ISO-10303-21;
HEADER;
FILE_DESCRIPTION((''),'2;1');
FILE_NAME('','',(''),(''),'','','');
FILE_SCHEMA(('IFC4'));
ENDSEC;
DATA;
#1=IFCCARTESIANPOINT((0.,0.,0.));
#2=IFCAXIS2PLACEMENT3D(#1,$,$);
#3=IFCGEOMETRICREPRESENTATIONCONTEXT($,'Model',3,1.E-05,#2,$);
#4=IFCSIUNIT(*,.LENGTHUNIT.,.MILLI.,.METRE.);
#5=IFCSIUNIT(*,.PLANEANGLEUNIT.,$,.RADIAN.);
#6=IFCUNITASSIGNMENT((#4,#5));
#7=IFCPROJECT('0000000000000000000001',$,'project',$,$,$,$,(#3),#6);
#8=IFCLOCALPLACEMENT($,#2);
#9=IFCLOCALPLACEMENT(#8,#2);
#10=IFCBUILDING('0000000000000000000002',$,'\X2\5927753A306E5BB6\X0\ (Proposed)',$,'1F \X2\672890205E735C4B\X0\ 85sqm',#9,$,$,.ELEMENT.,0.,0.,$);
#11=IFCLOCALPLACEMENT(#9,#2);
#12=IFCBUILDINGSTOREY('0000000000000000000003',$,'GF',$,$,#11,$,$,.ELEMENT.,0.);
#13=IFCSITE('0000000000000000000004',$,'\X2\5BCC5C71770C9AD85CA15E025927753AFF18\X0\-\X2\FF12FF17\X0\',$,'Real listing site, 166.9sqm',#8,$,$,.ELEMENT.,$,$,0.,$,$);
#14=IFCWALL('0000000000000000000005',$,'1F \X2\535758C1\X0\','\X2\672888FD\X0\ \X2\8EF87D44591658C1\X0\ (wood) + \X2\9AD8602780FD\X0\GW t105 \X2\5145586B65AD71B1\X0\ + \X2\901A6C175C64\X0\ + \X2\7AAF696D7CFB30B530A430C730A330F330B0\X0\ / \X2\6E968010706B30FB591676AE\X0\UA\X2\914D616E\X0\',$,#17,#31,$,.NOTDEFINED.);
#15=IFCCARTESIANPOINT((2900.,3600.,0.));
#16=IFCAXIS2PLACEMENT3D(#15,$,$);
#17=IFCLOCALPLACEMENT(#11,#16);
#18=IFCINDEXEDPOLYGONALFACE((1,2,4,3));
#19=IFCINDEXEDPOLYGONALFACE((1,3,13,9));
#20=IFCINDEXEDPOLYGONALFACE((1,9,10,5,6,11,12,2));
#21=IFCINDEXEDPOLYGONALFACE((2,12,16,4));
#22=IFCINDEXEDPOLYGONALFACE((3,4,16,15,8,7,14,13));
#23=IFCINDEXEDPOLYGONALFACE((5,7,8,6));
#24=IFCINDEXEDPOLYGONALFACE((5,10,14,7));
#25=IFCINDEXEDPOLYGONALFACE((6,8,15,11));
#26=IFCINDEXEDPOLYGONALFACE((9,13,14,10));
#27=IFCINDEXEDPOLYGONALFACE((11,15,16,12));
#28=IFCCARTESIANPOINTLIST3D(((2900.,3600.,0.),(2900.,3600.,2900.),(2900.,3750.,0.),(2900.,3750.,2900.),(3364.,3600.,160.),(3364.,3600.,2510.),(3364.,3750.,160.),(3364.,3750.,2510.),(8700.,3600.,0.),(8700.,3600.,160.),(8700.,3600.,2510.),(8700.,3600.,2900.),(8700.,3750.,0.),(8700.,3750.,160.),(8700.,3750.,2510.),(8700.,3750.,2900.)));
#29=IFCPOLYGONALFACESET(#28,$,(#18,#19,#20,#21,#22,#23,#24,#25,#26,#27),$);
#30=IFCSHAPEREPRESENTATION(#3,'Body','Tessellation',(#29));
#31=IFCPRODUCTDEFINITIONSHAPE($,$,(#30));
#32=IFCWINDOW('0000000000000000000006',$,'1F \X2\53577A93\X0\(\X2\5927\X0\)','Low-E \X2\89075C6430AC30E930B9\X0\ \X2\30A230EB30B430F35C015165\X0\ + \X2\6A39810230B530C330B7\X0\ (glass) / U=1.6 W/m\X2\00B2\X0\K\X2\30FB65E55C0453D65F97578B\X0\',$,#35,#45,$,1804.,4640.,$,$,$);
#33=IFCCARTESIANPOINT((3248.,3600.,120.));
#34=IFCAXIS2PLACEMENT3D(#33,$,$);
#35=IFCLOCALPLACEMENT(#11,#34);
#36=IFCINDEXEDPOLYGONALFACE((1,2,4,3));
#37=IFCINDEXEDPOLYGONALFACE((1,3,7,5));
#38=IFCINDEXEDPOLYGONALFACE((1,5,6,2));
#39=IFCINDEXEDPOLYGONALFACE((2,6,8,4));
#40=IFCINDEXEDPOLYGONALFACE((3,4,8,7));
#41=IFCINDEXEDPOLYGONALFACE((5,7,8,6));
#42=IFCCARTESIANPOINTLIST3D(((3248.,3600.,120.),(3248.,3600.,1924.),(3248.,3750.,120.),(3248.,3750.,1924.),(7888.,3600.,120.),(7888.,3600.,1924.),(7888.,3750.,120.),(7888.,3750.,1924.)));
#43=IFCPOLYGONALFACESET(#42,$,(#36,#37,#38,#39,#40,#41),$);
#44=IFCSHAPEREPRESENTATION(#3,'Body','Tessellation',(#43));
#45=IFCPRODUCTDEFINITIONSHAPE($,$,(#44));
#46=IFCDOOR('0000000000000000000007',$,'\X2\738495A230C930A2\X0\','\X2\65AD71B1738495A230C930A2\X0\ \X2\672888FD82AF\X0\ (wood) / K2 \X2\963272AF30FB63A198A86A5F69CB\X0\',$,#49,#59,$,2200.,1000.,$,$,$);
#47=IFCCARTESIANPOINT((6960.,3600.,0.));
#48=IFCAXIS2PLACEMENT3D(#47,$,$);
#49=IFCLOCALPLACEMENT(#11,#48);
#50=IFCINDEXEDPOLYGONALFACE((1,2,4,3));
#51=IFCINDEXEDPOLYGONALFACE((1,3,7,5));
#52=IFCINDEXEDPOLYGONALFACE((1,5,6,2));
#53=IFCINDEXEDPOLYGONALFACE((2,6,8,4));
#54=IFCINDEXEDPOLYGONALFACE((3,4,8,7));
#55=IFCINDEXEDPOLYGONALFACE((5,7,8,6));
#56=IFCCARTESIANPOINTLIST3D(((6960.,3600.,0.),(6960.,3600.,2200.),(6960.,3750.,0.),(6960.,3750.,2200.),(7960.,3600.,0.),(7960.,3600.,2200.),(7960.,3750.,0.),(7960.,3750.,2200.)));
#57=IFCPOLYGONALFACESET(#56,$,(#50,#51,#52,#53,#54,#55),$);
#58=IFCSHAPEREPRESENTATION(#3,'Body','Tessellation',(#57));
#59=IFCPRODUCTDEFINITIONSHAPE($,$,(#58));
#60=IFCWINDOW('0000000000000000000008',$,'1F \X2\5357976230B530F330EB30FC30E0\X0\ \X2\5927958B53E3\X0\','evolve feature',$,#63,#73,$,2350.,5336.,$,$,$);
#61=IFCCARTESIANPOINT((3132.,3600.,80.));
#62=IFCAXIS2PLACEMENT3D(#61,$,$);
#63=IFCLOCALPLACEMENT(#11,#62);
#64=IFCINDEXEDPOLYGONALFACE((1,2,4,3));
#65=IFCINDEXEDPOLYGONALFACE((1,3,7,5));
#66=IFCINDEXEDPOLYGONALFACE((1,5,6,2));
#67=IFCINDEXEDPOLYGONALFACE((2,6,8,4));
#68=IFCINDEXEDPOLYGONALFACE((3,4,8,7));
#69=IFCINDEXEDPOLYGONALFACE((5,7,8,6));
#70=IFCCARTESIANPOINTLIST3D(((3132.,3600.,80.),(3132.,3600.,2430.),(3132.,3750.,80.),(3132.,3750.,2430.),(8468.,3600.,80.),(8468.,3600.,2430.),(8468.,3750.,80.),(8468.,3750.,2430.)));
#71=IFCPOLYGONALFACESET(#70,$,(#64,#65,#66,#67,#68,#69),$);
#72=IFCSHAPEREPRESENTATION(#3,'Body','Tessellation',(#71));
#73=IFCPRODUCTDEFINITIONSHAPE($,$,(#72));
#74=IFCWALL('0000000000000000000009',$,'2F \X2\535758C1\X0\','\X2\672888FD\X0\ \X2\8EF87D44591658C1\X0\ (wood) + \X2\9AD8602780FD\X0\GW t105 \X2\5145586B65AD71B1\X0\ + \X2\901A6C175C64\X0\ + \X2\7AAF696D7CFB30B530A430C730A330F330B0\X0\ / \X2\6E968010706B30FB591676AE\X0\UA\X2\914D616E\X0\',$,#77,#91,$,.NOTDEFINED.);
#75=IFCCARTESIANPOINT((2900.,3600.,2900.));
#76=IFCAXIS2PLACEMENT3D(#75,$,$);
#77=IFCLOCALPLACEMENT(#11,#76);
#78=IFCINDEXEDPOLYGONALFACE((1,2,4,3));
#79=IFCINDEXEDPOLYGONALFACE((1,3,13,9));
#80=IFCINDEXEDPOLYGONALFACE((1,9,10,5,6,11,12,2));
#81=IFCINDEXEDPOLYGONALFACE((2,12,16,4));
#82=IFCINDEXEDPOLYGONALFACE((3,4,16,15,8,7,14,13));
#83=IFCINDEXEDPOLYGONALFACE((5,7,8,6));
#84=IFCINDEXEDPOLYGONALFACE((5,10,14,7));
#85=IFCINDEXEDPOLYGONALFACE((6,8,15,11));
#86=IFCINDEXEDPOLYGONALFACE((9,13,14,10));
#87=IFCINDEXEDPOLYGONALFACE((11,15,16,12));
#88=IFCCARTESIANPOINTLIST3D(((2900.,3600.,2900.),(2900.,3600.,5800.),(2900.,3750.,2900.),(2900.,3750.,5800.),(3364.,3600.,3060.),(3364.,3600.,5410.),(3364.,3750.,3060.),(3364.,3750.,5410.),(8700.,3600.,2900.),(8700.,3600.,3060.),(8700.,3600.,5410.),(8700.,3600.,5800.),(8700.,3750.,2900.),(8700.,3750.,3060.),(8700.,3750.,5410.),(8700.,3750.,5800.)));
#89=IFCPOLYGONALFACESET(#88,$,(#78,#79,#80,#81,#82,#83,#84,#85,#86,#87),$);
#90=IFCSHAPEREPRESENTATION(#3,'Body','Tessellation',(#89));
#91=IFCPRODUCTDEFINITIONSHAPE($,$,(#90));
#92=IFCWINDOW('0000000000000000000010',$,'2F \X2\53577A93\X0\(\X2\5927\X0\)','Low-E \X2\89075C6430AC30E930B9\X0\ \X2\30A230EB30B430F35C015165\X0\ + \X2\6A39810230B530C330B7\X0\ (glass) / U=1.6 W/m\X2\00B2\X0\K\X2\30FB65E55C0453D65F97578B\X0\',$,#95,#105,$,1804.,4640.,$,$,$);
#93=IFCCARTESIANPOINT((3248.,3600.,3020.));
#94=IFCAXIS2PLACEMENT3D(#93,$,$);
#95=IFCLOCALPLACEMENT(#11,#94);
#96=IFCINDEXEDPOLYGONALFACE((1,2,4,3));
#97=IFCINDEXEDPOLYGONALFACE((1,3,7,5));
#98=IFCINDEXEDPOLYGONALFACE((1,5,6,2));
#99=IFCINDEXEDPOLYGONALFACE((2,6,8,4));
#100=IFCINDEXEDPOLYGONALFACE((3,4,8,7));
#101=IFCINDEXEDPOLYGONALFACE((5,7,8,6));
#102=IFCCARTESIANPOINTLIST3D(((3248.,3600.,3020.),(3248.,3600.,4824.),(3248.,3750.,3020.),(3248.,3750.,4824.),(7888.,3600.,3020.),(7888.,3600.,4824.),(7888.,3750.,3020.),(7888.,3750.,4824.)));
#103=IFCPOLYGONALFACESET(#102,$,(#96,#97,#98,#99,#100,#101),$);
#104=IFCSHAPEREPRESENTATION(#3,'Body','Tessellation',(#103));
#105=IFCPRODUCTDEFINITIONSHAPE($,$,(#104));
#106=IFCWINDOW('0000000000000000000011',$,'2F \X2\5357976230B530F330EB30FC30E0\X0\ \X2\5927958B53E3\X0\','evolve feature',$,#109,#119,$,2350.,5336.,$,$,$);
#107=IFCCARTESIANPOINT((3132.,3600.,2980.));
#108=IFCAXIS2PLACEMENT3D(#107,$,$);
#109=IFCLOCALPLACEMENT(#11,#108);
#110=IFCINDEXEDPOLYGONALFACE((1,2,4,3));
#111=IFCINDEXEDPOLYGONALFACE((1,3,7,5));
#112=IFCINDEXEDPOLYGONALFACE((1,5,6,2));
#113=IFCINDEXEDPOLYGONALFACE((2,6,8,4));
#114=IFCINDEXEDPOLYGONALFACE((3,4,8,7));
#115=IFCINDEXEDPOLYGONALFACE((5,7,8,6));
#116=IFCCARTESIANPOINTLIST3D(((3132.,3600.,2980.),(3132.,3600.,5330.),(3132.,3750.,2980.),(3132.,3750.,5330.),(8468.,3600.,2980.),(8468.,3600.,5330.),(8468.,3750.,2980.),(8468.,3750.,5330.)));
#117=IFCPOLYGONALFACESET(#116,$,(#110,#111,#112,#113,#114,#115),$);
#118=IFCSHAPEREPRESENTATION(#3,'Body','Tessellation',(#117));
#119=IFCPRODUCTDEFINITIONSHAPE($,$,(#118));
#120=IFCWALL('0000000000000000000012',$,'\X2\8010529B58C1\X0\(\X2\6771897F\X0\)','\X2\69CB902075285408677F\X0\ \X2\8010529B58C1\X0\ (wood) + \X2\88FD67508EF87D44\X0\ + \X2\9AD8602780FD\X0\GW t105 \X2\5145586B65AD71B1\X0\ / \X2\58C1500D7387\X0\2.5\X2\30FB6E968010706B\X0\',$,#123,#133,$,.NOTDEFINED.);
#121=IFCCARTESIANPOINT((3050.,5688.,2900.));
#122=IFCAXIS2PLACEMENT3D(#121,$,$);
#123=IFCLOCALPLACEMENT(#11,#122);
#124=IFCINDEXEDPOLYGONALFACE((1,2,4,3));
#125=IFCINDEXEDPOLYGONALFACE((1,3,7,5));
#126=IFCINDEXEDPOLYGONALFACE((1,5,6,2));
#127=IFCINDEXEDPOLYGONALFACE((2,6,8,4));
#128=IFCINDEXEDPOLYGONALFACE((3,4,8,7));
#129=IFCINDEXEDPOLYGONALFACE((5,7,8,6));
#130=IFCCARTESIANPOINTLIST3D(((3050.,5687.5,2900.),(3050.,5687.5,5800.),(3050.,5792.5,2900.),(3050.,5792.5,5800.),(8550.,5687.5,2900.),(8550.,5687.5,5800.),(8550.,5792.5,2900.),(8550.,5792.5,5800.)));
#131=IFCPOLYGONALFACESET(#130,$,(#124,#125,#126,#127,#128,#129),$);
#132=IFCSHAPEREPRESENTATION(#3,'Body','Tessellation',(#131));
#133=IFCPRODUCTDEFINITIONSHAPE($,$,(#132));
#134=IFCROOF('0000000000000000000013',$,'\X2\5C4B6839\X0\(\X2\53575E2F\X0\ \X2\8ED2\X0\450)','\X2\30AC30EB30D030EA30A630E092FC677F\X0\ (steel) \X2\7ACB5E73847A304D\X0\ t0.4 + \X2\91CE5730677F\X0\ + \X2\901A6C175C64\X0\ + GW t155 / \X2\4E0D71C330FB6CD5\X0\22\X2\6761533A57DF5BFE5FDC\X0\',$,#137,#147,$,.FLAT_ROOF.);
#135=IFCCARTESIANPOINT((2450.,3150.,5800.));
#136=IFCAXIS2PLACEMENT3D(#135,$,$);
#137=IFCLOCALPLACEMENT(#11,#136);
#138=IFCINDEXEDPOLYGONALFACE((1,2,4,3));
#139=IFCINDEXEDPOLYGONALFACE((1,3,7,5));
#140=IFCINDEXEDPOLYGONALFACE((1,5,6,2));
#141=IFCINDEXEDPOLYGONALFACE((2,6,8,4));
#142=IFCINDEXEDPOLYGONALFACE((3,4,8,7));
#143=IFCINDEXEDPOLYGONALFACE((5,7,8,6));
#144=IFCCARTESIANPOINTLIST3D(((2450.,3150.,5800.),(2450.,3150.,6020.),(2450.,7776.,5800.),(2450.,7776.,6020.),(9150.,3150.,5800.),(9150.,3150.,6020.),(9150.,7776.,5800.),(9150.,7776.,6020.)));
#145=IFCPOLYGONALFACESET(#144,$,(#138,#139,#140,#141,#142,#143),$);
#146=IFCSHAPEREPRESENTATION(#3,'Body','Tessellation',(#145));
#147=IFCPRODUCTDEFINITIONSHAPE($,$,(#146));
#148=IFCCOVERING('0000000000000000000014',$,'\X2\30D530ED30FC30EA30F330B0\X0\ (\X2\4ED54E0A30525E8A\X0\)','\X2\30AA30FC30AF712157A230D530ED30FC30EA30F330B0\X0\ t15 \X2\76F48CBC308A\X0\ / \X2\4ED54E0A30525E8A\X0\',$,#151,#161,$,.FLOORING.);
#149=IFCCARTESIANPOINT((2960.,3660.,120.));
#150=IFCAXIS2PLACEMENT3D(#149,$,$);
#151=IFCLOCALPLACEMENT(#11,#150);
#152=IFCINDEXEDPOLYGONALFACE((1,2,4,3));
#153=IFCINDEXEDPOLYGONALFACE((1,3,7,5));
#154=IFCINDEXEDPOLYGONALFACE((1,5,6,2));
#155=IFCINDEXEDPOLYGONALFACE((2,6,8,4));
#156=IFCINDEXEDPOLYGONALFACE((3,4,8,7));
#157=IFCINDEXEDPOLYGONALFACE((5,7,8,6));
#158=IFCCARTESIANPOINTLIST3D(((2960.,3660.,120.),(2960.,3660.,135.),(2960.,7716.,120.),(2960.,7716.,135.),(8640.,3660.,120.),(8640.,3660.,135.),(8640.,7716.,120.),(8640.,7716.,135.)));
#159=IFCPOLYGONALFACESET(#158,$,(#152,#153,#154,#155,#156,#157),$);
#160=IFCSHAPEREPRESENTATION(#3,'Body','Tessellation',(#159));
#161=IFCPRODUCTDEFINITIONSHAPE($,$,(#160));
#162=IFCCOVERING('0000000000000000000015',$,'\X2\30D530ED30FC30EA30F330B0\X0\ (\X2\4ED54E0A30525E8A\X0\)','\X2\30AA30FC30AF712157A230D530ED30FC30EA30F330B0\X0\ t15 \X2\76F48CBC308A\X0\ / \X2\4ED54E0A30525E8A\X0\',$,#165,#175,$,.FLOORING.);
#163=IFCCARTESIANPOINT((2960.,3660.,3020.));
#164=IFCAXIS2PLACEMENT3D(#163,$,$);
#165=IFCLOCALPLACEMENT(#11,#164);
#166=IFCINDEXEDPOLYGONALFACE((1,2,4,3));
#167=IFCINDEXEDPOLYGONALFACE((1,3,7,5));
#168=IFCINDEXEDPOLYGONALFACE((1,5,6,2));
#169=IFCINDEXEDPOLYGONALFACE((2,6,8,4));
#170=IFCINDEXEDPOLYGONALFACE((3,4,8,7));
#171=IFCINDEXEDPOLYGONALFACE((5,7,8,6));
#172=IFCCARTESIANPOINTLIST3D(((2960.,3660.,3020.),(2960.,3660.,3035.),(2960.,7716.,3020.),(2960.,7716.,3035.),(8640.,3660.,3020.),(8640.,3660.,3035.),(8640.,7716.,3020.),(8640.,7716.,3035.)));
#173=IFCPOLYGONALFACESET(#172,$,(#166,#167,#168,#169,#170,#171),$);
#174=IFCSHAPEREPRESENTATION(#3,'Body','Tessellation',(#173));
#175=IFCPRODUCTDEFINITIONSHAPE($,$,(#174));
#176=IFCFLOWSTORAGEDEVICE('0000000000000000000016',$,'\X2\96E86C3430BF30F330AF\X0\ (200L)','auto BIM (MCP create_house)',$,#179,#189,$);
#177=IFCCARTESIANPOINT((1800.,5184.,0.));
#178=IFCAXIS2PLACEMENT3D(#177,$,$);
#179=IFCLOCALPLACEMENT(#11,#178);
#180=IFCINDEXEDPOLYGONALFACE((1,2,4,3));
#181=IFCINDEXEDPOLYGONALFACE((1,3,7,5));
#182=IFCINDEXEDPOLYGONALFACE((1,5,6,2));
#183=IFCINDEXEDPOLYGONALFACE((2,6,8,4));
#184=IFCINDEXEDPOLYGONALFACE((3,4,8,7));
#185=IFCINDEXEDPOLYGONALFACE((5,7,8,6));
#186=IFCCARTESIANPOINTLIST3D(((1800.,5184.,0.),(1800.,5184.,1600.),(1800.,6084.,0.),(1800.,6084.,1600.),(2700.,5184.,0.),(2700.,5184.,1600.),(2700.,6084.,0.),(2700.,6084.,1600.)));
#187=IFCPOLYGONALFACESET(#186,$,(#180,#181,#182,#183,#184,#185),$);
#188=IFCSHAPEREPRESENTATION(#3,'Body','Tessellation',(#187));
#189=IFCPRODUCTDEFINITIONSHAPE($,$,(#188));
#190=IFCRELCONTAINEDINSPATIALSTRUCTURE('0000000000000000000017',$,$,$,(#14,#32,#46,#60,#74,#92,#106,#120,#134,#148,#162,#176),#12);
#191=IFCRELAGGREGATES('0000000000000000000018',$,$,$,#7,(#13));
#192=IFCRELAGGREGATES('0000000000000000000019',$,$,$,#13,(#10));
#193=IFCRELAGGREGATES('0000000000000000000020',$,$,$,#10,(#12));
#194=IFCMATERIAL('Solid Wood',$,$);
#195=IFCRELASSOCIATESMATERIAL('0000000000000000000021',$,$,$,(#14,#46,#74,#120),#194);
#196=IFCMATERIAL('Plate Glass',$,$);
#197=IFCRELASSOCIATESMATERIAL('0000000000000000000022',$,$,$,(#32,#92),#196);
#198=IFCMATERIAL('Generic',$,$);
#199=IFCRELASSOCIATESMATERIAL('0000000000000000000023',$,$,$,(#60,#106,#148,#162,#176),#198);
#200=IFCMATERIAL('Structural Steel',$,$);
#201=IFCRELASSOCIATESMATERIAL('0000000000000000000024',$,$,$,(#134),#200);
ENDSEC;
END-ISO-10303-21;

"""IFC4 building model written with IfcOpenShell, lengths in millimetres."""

from ifc_helpers import new_model, si_unit, frame, frame_2d, origin, place, context, project, spatial, rectangle, extrude, material, element, fill, save


model = new_model("IFC4")

# Units and contexts
model_context = context("Model", 3, precision=1e-05, world=origin())
ifc_project = project(units=[si_unit("LENGTHUNIT", "METRE", prefix="MILLI"), si_unit("PLANEANGLEUNIT", "RADIAN")], contexts=[model_context])

# Site, building, storey
site_placement = place(None, origin())
site = spatial("IfcSite", under=ifc_project, at=site_placement, Name="富山県高岡市大町８-２７", ObjectType="Real listing site, 166.9sqm", CompositionType="ELEMENT", RefElevation=0.0)
building_placement = place(site_placement, origin())
building = spatial("IfcBuilding", under=site, at=building_placement, Name="大町の家 (Proposed)", ObjectType="1F 木造平屋 85sqm", CompositionType="ELEMENT", ElevationOfRefHeight=0.0, ElevationOfTerrain=0.0)
storey_placement = place(building_placement, origin())
storey = spatial("IfcBuildingStorey", under=building, at=storey_placement, Name="GF", CompositionType="ELEMENT", Elevation=0.0)

# Shared definitions
ifc_material_1 = material(Name="Solid Wood")
ifc_material_2 = material(Name="Generic")

# Wall, openings, windows, door
wall_1_placement = place(storey_placement, frame((2900.0, 3600.0, 0.0)))
wall_1 = element("IfcWall", 1, at=wall_1_placement, inside=storey, material=ifc_material_1, Name="1F 南壁", Description="木製 軸組外壁 (wood) + 高性能GW t105 充填断熱 + 通気層 + 窯業系サイディング / 準耐火・外皮UA配慮", PredefinedType="NOTDEFINED", context=model_context, shape_type="SweptSolid", body=[
    extrude(rectangle(XDim=5800.0, YDim=150.0, at=frame_2d((2900.0, 75.0))), frame((2900.0, 3600.0, 0.0)), (0.0, 0.0, 1.0), 2900.0),
])
opening_1_placement = place(storey_placement, frame((3248.0, 3600.0, 120.0)))
opening_1 = element("IfcOpeningElement", 2, at=opening_1_placement, cuts=wall_1, PredefinedType="NOTDEFINED", context=model_context, shape_type="SweptSolid", body=[
    extrude(rectangle(XDim=4640.0, YDim=150.0, at=frame_2d((2320.0, 75.0))), frame((3248.0, 3600.0, 120.0)), (0.0, 0.0, 1.0), 1804.0),
])
opening_2_placement = place(storey_placement, frame((6960.0, 3600.0, 0.0)))
opening_2 = element("IfcOpeningElement", 3, at=opening_2_placement, cuts=wall_1, PredefinedType="NOTDEFINED", context=model_context, shape_type="SweptSolid", body=[
    extrude(rectangle(XDim=1000.0, YDim=150.0, at=frame_2d((500.0, 75.0))), frame((6960.0, 3600.0, 0.0)), (0.0, 0.0, 1.0), 2200.0),
])
opening_3_placement = place(storey_placement, frame((3132.0, 3600.0, 80.0)))
opening_3 = element("IfcOpeningElement", 4, at=opening_3_placement, cuts=wall_1, PredefinedType="NOTDEFINED", context=model_context, shape_type="SweptSolid", body=[
    extrude(rectangle(XDim=5336.0, YDim=150.0, at=frame_2d((2668.0, 75.0))), frame((3132.0, 3600.0, 80.0)), (0.0, 0.0, 1.0), 2350.0),
])
ifc_material_3 = material(Name="Plate Glass")
window_1_placement = place(storey_placement, frame((3248.0, 3600.0, 120.0)))
window_1 = element("IfcWindow", 5, at=window_1_placement, inside=storey, material=ifc_material_3, Name="1F 南窓(大)", Description="Low-E 複層ガラス アルゴン封入 + 樹脂サッシ (glass) / U=1.6 W/m²K・日射取得型", OverallHeight=1804.0, OverallWidth=4640.0, context=model_context, shape_type="SweptSolid", body=[
    extrude(rectangle(XDim=4640.0, YDim=150.0, at=frame_2d((2320.0, 75.0))), frame((3248.0, 3600.0, 120.0)), (0.0, 0.0, 1.0), 1804.0),
])
fill(opening_1, window_1)
door_placement = place(storey_placement, frame((6960.0, 3600.0, 0.0)))
door = element("IfcDoor", 6, at=door_placement, inside=storey, material=ifc_material_1, Name="玄関ドア", Description="断熱玄関ドア 木製芯 (wood) / K2 防犯・採風機構", OverallHeight=2200.0, OverallWidth=1000.0, context=model_context, shape_type="SweptSolid", body=[
    extrude(rectangle(XDim=1000.0, YDim=150.0, at=frame_2d((500.0, 75.0))), frame((6960.0, 3600.0, 0.0)), (0.0, 0.0, 1.0), 2200.0),
])
fill(opening_2, door)
window_2_placement = place(storey_placement, frame((3132.0, 3600.0, 80.0)))
window_2 = element("IfcWindow", 7, at=window_2_placement, inside=storey, material=ifc_material_2, Name="1F 南面サンルーム 大開口", Description="evolve feature", OverallHeight=2350.0, OverallWidth=5336.0, context=model_context, shape_type="SweptSolid", body=[
    extrude(rectangle(XDim=5336.0, YDim=150.0, at=frame_2d((2668.0, 75.0))), frame((3132.0, 3600.0, 80.0)), (0.0, 0.0, 1.0), 2350.0),
])
fill(opening_3, window_2)

# Wall, openings, windows
wall_2_placement = place(storey_placement, frame((2900.0, 3600.0, 2900.0)))
wall_2 = element("IfcWall", 8, at=wall_2_placement, inside=storey, material=ifc_material_1, Name="2F 南壁", Description="木製 軸組外壁 (wood) + 高性能GW t105 充填断熱 + 通気層 + 窯業系サイディング / 準耐火・外皮UA配慮", PredefinedType="NOTDEFINED", context=model_context, shape_type="SweptSolid", body=[
    extrude(rectangle(XDim=5800.0, YDim=150.0, at=frame_2d((2900.0, 75.0))), frame((2900.0, 3600.0, 2900.0)), (0.0, 0.0, 1.0), 2900.0),
])
opening_4_placement = place(storey_placement, frame((3248.0, 3600.0, 3020.0)))
opening_4 = element("IfcOpeningElement", 9, at=opening_4_placement, cuts=wall_2, PredefinedType="NOTDEFINED", context=model_context, shape_type="SweptSolid", body=[
    extrude(rectangle(XDim=4640.0, YDim=150.0, at=frame_2d((2320.0, 75.0))), frame((3248.0, 3600.0, 3020.0)), (0.0, 0.0, 1.0), 1804.0),
])
opening_5_placement = place(storey_placement, frame((3132.0, 3600.0, 2980.0)))
opening_5 = element("IfcOpeningElement", 10, at=opening_5_placement, cuts=wall_2, PredefinedType="NOTDEFINED", context=model_context, shape_type="SweptSolid", body=[
    extrude(rectangle(XDim=5336.0, YDim=150.0, at=frame_2d((2668.0, 75.0))), frame((3132.0, 3600.0, 2980.0)), (0.0, 0.0, 1.0), 2350.0),
])
window_3_placement = place(storey_placement, frame((3248.0, 3600.0, 3020.0)))
window_3 = element("IfcWindow", 11, at=window_3_placement, inside=storey, material=ifc_material_3, Name="2F 南窓(大)", Description="Low-E 複層ガラス アルゴン封入 + 樹脂サッシ (glass) / U=1.6 W/m²K・日射取得型", OverallHeight=1804.0, OverallWidth=4640.0, context=model_context, shape_type="SweptSolid", body=[
    extrude(rectangle(XDim=4640.0, YDim=150.0, at=frame_2d((2320.0, 75.0))), frame((3248.0, 3600.0, 3020.0)), (0.0, 0.0, 1.0), 1804.0),
])
fill(opening_4, window_3)
window_4_placement = place(storey_placement, frame((3132.0, 3600.0, 2980.0)))
window_4 = element("IfcWindow", 12, at=window_4_placement, inside=storey, material=ifc_material_2, Name="2F 南面サンルーム 大開口", Description="evolve feature", OverallHeight=2350.0, OverallWidth=5336.0, context=model_context, shape_type="SweptSolid", body=[
    extrude(rectangle(XDim=5336.0, YDim=150.0, at=frame_2d((2668.0, 75.0))), frame((3132.0, 3600.0, 2980.0)), (0.0, 0.0, 1.0), 2350.0),
])
fill(opening_5, window_4)

# Wall
wall_3_placement = place(storey_placement, frame((3050.0, 5688.0, 2900.0)))
element("IfcWall", 13, at=wall_3_placement, inside=storey, material=ifc_material_1, Name="耐力壁(東西)", Description="構造用合板 耐力壁 (wood) + 製材軸組 + 高性能GW t105 充填断熱 / 壁倍率2.5・準耐火", PredefinedType="NOTDEFINED", context=model_context, shape_type="SweptSolid", body=[
    extrude(rectangle(XDim=5500.0, YDim=105.0, at=frame_2d((2750.0, 52.0))), frame((3050.0, 5688.0, 2900.0)), (0.0, 0.0, 1.0), 2900.0),
])

# Roof
ifc_material_4 = material(Name="Structural Steel")
for number, where, name in (
    (14, (2450.0, 3150.0, 5800.0), "屋根(南帯 軒450)"),
):
    element("IfcRoof", number, at=place(storey_placement, frame(where)), inside=storey, material=ifc_material_4, Name=name, Description="ガルバリウム鋼板 (steel) 立平葺き t0.4 + 野地板 + 通気層 + GW t155 / 不燃・法22条区域対応", PredefinedType="FLAT_ROOF", context=model_context, shape_type="SweptSolid", body=[
        extrude(rectangle(XDim=6700.0, YDim=4626.0, at=frame_2d((3350.0, 2313.0))), frame((2450.0, 3150.0, 5800.0)), (0.0, 0.0, 1.0), 220.0),
    ])

# Coverings
covering_1_placement = place(storey_placement, frame((2960.0, 3660.0, 120.0)))
element("IfcCovering", 15, at=covering_1_placement, inside=storey, material=ifc_material_2, Name="フローリング (仕上げ床)", Description="オーク無垢フローリング t15 直貼り / 仕上げ床", PredefinedType="FLOORING", context=model_context, shape_type="SweptSolid", body=[
    extrude(rectangle(XDim=5680.0, YDim=4056.0, at=frame_2d((2840.0, 2028.0))), frame((2960.0, 3660.0, 120.0)), (0.0, 0.0, 1.0), 15.0),
])
covering_2_placement = place(storey_placement, frame((2960.0, 3660.0, 3020.0)))
element("IfcCovering", 16, at=covering_2_placement, inside=storey, material=ifc_material_2, Name="フローリング (仕上げ床)", Description="オーク無垢フローリング t15 直貼り / 仕上げ床", PredefinedType="FLOORING", context=model_context, shape_type="SweptSolid", body=[
    extrude(rectangle(XDim=5680.0, YDim=4056.0, at=frame_2d((2840.0, 2028.0))), frame((2960.0, 3660.0, 3020.0)), (0.0, 0.0, 1.0), 15.0),
])

# Flow storage device
flow_storage_device_placement = place(storey_placement, frame((1800.0, 5184.0, 0.0)))
element("IfcFlowStorageDevice", 17, at=flow_storage_device_placement, inside=storey, material=ifc_material_2, Name="雨水タンク (200L)", Description="auto BIM (MCP create_house)", context=model_context, shape_type="SweptSolid", body=[
    extrude(rectangle(XDim=900.0, YDim=900.0, at=frame_2d((450.0, 450.0))), frame((1800.0, 5184.0, 0.0)), (0.0, 0.0, 1.0), 1600.0),
])

save(model, "model.ifc")
